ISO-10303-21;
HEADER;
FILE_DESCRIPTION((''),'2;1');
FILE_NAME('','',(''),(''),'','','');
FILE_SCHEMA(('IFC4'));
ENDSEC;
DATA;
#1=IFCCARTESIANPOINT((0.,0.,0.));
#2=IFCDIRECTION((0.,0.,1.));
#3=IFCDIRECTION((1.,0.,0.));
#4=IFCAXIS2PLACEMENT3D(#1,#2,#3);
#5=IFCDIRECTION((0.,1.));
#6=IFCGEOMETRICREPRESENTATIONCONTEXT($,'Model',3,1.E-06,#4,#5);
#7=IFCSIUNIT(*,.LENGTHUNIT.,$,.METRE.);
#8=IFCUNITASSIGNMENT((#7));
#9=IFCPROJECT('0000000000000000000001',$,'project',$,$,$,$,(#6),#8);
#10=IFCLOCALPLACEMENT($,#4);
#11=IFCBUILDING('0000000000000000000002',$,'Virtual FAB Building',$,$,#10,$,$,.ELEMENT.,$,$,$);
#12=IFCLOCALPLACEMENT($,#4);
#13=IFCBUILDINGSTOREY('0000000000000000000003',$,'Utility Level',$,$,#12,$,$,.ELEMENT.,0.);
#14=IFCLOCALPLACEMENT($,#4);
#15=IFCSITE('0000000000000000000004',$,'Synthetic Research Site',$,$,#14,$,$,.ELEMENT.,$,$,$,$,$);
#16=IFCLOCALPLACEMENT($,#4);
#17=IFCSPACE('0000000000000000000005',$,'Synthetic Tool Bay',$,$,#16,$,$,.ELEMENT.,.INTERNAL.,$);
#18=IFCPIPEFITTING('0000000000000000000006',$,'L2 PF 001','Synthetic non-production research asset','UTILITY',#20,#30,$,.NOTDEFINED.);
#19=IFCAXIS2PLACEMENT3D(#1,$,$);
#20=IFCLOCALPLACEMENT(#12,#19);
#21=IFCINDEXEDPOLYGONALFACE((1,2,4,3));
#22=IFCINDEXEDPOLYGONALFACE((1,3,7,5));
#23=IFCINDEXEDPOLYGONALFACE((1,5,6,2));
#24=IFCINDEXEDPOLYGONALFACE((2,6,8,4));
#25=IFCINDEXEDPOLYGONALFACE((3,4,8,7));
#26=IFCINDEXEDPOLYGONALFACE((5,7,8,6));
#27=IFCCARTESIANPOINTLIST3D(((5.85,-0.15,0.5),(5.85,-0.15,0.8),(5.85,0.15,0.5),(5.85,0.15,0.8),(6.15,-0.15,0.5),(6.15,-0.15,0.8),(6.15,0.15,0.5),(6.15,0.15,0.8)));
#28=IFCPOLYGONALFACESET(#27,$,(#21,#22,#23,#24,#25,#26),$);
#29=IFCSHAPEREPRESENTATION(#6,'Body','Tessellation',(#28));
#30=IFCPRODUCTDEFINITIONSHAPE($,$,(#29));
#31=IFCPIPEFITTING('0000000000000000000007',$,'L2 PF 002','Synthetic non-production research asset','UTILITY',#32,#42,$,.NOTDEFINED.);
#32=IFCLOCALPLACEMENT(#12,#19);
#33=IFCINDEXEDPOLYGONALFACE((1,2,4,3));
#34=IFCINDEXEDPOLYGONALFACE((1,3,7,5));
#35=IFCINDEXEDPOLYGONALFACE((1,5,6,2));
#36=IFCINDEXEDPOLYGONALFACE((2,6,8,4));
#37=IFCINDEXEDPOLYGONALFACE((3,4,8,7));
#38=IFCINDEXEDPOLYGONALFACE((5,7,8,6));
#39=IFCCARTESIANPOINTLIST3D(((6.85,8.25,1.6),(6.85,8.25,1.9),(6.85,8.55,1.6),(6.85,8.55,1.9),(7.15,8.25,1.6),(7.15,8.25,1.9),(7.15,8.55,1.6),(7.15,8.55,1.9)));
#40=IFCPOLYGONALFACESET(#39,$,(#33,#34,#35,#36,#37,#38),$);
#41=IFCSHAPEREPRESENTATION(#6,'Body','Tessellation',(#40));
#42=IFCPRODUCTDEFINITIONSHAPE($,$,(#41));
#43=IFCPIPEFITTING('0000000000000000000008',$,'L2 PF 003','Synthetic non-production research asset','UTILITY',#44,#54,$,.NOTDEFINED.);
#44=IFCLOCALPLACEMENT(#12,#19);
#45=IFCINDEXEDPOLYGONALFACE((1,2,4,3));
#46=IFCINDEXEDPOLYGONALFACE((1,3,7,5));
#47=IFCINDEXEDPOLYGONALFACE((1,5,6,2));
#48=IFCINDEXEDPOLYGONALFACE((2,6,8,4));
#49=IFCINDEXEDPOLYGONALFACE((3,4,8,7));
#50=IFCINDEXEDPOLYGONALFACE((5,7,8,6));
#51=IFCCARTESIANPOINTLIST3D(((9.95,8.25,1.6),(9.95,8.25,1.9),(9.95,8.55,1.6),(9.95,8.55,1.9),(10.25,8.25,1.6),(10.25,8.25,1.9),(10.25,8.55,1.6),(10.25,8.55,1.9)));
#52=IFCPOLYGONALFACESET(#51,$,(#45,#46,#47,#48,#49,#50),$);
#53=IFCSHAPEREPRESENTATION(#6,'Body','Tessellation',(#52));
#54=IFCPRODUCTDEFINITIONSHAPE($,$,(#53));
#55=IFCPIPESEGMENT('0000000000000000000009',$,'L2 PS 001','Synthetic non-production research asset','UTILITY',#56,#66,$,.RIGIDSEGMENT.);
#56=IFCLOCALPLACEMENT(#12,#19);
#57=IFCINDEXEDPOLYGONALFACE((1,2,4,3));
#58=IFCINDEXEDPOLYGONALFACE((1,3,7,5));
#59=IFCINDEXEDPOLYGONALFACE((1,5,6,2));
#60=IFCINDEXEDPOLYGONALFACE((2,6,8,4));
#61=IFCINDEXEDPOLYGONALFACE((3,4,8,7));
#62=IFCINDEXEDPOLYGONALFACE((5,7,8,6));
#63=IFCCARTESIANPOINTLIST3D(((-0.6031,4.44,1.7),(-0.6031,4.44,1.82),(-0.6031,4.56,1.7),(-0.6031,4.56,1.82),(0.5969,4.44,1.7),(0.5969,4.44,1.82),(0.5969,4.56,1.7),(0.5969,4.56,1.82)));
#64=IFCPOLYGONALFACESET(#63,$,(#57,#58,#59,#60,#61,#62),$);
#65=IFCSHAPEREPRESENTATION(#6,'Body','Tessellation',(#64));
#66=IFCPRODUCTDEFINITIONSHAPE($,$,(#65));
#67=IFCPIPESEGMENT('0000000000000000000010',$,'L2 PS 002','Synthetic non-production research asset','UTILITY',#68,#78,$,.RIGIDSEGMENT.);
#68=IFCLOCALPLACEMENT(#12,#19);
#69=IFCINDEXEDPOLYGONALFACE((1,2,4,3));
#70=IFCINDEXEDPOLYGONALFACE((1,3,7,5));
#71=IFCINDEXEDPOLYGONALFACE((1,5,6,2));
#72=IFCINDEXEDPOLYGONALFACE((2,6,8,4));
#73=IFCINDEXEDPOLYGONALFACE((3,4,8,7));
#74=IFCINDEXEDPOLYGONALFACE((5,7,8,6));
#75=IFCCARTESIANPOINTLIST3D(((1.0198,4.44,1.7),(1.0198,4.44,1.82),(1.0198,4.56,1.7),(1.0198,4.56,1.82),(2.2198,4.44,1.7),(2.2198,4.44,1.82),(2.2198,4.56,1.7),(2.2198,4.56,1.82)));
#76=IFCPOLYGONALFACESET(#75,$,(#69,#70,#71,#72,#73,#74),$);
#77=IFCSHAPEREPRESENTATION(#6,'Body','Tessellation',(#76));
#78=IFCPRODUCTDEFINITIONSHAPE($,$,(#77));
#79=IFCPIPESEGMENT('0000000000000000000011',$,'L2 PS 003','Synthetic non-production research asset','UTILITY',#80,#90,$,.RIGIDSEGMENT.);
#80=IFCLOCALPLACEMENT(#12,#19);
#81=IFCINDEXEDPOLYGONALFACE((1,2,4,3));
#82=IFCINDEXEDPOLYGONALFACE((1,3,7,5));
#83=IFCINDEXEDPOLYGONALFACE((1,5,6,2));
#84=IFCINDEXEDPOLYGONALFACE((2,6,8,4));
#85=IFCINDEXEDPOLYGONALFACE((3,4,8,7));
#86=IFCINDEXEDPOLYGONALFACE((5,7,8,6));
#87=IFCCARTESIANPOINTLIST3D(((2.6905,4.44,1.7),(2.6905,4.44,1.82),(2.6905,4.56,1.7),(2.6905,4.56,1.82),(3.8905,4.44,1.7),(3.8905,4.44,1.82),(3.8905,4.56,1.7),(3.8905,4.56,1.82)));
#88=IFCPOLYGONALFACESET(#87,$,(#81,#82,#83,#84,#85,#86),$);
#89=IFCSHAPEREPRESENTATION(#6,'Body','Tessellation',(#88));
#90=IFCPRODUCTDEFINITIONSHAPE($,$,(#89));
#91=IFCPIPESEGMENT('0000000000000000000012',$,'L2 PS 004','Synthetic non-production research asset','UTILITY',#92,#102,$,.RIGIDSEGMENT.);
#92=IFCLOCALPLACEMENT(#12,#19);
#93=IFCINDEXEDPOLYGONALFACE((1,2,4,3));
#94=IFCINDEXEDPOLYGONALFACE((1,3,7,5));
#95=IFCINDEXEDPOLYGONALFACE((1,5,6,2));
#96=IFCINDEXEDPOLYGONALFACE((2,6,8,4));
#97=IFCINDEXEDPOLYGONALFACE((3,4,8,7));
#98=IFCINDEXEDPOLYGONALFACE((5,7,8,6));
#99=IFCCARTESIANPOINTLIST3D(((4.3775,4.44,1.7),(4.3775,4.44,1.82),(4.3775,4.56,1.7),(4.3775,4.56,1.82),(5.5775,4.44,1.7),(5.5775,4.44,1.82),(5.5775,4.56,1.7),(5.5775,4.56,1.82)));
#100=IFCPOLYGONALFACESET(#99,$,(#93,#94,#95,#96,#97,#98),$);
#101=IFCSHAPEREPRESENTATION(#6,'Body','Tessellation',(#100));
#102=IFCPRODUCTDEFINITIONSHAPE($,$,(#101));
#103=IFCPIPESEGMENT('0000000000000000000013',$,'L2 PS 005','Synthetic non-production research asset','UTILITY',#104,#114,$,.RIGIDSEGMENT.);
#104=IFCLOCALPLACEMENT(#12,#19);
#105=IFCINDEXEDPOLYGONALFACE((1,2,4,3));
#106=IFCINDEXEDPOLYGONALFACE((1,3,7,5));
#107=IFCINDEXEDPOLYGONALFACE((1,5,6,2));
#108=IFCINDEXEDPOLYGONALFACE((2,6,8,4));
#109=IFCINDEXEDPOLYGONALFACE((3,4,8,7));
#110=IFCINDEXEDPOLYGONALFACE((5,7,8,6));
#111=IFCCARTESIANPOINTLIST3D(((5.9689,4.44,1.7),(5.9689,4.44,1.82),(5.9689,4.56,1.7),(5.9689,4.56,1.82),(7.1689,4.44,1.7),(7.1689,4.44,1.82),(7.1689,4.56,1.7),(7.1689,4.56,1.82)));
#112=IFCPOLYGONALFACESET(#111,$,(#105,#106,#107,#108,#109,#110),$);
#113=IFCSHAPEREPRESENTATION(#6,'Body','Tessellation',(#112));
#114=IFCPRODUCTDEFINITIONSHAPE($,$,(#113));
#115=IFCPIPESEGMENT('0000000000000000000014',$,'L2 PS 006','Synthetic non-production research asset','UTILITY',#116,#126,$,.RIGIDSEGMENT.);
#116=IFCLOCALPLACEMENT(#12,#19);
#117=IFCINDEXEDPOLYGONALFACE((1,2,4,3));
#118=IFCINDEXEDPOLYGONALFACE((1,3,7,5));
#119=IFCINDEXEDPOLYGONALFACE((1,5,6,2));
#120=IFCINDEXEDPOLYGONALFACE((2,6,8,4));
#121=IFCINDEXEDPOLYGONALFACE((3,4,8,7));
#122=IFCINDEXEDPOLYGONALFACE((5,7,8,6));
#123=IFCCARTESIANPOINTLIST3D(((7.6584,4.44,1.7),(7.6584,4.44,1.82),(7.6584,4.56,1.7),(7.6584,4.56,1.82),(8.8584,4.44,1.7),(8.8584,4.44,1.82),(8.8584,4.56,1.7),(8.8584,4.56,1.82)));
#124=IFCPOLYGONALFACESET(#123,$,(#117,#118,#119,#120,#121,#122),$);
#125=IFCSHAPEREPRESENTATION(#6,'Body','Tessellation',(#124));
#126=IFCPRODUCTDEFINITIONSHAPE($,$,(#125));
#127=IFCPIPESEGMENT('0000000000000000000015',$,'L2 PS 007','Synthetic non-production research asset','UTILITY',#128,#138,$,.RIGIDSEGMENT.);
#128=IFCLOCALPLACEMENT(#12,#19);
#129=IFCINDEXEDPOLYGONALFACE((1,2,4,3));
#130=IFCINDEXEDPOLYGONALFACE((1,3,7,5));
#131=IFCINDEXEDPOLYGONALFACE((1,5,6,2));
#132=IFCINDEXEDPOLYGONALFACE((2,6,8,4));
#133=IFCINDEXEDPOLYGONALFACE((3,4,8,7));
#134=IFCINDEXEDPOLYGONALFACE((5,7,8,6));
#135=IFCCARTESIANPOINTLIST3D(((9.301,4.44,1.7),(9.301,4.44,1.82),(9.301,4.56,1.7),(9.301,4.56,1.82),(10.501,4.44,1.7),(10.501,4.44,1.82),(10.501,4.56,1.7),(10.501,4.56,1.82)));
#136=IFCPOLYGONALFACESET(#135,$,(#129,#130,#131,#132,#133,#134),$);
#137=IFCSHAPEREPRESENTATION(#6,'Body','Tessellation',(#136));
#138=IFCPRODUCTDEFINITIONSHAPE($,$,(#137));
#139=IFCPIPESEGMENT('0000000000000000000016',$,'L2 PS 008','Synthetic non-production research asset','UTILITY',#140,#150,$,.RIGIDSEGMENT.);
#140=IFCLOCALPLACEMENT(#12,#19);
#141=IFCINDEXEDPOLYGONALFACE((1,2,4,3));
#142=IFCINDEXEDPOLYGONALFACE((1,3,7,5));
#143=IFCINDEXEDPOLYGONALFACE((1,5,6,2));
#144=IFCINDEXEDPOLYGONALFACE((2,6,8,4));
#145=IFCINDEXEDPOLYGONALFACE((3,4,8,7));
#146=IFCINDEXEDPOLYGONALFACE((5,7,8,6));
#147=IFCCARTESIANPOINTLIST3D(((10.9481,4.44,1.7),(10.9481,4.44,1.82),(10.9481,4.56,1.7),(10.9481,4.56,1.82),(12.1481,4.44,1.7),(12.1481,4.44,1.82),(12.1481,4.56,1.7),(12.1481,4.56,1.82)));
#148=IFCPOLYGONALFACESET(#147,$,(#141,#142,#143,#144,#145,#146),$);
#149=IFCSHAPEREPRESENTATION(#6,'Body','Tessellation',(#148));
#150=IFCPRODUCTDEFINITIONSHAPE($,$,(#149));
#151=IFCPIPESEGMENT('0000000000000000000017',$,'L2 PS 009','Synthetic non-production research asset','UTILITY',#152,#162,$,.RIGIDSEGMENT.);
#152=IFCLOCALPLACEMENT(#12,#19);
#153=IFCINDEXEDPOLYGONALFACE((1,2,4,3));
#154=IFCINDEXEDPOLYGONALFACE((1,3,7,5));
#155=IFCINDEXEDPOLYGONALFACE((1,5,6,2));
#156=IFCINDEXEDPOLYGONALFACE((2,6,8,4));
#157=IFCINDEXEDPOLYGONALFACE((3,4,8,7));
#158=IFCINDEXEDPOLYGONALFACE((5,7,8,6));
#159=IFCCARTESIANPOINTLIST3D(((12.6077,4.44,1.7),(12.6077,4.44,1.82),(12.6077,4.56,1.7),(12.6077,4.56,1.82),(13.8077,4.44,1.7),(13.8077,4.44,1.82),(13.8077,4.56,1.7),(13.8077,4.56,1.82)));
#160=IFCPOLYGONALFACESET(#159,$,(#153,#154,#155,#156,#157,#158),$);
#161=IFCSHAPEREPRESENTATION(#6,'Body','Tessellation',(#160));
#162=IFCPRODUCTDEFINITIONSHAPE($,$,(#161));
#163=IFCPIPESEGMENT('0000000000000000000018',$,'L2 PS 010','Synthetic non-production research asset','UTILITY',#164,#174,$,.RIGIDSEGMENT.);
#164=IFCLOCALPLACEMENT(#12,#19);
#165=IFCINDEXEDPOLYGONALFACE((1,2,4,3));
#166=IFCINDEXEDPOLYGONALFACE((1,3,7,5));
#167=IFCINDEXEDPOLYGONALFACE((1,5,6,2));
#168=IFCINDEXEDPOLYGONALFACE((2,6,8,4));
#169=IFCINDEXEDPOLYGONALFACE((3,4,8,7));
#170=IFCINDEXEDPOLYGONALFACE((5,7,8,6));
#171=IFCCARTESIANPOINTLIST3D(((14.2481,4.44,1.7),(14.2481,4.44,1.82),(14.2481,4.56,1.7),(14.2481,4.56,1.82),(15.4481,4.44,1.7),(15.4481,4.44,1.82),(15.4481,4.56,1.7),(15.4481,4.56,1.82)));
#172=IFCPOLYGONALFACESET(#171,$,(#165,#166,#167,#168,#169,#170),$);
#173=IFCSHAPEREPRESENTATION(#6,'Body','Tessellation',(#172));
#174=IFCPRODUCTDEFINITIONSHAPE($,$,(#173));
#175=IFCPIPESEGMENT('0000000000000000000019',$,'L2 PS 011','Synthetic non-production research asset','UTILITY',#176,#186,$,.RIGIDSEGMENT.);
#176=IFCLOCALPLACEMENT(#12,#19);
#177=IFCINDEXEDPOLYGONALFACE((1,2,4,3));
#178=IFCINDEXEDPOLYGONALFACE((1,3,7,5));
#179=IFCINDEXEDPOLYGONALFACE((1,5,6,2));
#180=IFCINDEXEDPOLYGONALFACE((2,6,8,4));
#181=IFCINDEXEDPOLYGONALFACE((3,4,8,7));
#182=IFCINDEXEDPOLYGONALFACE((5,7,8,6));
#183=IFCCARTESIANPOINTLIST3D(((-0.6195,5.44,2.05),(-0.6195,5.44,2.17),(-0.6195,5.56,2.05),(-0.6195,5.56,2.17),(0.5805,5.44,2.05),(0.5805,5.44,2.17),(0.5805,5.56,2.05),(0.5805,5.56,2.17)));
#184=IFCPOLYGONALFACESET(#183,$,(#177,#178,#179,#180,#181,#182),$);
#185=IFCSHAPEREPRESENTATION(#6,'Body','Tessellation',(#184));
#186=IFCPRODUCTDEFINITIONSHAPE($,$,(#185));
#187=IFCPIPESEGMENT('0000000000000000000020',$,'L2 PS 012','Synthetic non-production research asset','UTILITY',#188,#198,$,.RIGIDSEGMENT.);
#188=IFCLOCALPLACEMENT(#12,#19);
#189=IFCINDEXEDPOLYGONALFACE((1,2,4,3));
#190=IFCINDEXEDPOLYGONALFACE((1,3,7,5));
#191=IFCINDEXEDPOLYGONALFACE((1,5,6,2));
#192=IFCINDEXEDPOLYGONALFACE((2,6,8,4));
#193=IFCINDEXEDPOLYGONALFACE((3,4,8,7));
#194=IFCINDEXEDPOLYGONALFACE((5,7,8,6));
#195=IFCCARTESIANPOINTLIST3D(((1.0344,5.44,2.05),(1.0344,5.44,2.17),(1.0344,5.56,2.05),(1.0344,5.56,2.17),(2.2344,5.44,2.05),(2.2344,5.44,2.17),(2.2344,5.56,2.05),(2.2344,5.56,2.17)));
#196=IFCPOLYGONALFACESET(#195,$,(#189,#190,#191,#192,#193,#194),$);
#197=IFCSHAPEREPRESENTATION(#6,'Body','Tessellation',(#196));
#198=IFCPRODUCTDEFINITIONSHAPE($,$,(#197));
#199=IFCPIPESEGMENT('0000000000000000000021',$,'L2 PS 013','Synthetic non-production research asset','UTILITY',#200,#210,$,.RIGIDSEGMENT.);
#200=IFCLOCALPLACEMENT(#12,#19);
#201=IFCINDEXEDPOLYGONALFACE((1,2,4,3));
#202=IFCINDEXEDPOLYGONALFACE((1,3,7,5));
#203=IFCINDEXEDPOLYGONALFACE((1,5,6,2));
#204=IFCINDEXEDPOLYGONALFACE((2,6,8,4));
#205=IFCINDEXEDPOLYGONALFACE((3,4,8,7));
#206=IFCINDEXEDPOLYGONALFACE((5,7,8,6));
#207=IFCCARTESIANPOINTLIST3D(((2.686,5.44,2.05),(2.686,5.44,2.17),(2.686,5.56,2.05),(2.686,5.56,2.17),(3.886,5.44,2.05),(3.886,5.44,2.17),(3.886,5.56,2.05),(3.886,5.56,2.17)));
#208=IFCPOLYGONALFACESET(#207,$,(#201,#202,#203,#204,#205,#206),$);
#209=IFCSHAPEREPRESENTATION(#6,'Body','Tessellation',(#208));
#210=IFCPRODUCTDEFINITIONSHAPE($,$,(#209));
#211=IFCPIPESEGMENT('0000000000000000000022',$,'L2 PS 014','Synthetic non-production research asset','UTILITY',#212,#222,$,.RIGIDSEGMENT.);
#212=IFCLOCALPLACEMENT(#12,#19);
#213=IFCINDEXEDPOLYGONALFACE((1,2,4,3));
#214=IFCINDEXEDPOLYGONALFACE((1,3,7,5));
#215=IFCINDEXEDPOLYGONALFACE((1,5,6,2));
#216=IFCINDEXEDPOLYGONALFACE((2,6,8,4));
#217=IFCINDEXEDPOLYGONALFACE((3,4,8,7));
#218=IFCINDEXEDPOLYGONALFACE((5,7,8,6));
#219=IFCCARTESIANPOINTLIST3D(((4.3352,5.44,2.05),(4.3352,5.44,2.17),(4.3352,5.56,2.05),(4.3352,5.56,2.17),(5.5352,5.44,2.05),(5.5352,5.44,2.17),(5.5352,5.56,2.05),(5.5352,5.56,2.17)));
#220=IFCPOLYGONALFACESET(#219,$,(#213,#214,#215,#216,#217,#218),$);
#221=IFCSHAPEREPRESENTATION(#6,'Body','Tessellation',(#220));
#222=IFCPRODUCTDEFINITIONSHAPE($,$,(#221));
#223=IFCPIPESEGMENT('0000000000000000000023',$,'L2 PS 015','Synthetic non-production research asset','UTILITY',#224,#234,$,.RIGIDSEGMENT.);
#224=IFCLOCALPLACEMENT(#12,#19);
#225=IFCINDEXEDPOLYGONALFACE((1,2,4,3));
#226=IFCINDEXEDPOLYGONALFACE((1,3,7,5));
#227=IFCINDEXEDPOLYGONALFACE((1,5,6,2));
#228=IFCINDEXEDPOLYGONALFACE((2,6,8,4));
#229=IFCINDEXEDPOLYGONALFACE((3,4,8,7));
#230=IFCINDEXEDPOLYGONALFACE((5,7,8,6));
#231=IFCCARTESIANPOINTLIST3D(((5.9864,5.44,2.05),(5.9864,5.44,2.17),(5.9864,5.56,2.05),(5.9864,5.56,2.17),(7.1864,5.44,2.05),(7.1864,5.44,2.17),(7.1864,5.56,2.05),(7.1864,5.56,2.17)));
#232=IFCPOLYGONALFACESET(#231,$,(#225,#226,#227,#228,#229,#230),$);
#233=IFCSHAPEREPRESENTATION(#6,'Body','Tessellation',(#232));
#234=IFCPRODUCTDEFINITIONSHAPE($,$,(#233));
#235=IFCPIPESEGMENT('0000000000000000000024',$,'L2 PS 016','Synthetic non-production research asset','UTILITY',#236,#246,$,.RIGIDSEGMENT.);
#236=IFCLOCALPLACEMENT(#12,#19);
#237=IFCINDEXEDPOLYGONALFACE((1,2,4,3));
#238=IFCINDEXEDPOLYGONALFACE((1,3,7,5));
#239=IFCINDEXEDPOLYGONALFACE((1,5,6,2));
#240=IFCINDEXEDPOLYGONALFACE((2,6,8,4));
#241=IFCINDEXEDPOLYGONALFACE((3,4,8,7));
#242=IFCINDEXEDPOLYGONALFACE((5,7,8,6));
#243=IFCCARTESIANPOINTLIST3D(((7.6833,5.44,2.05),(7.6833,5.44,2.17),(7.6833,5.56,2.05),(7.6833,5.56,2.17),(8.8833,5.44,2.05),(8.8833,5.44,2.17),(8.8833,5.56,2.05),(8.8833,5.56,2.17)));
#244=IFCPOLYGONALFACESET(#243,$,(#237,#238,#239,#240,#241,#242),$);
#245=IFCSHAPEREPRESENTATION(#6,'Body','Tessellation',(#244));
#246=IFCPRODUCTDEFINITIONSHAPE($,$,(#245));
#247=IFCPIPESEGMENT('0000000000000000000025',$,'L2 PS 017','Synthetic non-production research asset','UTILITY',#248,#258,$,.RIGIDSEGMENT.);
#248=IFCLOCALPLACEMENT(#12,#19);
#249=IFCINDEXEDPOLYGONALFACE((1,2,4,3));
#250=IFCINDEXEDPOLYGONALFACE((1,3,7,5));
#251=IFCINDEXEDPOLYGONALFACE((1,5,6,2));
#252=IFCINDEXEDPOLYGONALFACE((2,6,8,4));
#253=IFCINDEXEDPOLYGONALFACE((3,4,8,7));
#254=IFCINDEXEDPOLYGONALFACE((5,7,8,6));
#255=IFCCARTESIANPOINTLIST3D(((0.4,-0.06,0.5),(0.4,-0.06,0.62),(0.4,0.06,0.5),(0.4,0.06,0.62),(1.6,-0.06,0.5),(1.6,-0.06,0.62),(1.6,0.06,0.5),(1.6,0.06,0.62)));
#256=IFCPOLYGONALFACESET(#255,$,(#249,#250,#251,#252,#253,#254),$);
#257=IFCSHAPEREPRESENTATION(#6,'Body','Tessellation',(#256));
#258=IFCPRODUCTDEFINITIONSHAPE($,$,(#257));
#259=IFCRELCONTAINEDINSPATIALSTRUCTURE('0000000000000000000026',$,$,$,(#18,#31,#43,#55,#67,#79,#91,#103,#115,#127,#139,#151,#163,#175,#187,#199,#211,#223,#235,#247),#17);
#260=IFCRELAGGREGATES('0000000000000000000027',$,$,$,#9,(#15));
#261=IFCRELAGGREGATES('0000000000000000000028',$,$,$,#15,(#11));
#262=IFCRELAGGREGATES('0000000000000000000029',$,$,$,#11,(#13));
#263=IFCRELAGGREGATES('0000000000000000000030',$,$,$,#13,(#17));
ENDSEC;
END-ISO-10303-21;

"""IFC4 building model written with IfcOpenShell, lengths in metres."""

from ifc_helpers import new_model, si_unit, direction, frame, origin_with_axes, origin_2d_with_axis, place, context, project, spatial, rectangle, extrude, element, save


model = new_model("IFC4")

# Units and contexts
model_context = context("Model", 3, precision=1e-06, world=origin_with_axes(), true_north=direction((0.0, 1.0)))
ifc_project = project(units=[si_unit("LENGTHUNIT", "METRE")], contexts=[model_context])

# Site, building, storey, space
site_placement = place(None, origin_with_axes())
site = spatial("IfcSite", under=ifc_project, at=site_placement, Name="Synthetic Research Site", CompositionType="ELEMENT")
building_placement = place(None, origin_with_axes())
building = spatial("IfcBuilding", under=site, at=building_placement, Name="Virtual FAB Building", CompositionType="ELEMENT")
storey_placement = place(None, origin_with_axes())
storey = spatial("IfcBuildingStorey", under=building, at=storey_placement, Name="Utility Level", CompositionType="ELEMENT", Elevation=0.0)
space_placement = place(None, origin_with_axes())
space = spatial("IfcSpace", under=storey, at=space_placement, Name="Synthetic Tool Bay", CompositionType="ELEMENT", PredefinedType="INTERNAL")

# Pipe fittings
for number, where, z_axis, x_axis, name in (
    (1, (6.0, 0.0, 0.5), (0.0, 0.0, 1.0), (1.0, 0.0, 0.0), "L2 PF 001"),
    (2, (7.0, 8.4, 1.6), (0.0, 0.0, 1.0), (1.0, 0.0, 0.0), "L2 PF 002"),
    (3, (10.1, 8.4, 1.6), (0.0, 0.0, 1.0), (1.0, 0.0, 0.0), "L2 PF 003"),
):
    element("IfcPipeFitting", number, at=place(None, frame(where, z_axis=z_axis, x_axis=x_axis)), inside=space, Name=name, Description="Synthetic non-production research asset", ObjectType="UTILITY", PredefinedType="NOTDEFINED", context=model_context, shape_type="SweptSolid", body=[
        extrude(rectangle(XDim=0.3, YDim=0.3, at=origin_2d_with_axis()), origin_with_axes(), (0.0, 0.0, 1.0), 0.3),
    ])

# Pipe segments
for number, where, z_axis, x_axis, name in (
    (4, (-0.0031, 4.5, 1.7), (0.0, 0.0, 1.0), (1.0, 0.0, 0.0), "L2 PS 001"),
    (5, (1.6198, 4.5, 1.7), (0.0, 0.0, 1.0), (1.0, 0.0, 0.0), "L2 PS 002"),
    (6, (3.2905, 4.5, 1.7), (0.0, 0.0, 1.0), (1.0, 0.0, 0.0), "L2 PS 003"),
    (7, (4.9775, 4.5, 1.7), (0.0, 0.0, 1.0), (1.0, 0.0, 0.0), "L2 PS 004"),
    (8, (6.5689, 4.5, 1.7), (0.0, 0.0, 1.0), (1.0, 0.0, 0.0), "L2 PS 005"),
    (9, (8.2584, 4.5, 1.7), (0.0, 0.0, 1.0), (1.0, 0.0, 0.0), "L2 PS 006"),
    (10, (9.901, 4.5, 1.7), (0.0, 0.0, 1.0), (1.0, 0.0, 0.0), "L2 PS 007"),
    (11, (11.5481, 4.5, 1.7), (0.0, 0.0, 1.0), (1.0, 0.0, 0.0), "L2 PS 008"),
    (12, (13.2077, 4.5, 1.7), (0.0, 0.0, 1.0), (1.0, 0.0, 0.0), "L2 PS 009"),
    (13, (14.8481, 4.5, 1.7), (0.0, 0.0, 1.0), (1.0, 0.0, 0.0), "L2 PS 010"),
    (14, (-0.0195, 5.5, 2.05), (0.0, 0.0, 1.0), (1.0, 0.0, 0.0), "L2 PS 011"),
    (15, (1.6344, 5.5, 2.05), (0.0, 0.0, 1.0), (1.0, 0.0, 0.0), "L2 PS 012"),
    (16, (3.286, 5.5, 2.05), (0.0, 0.0, 1.0), (1.0, 0.0, 0.0), "L2 PS 013"),
    (17, (4.9352, 5.5, 2.05), (0.0, 0.0, 1.0), (1.0, 0.0, 0.0), "L2 PS 014"),
    (18, (6.5864, 5.5, 2.05), (0.0, 0.0, 1.0), (1.0, 0.0, 0.0), "L2 PS 015"),
    (19, (8.2833, 5.5, 2.05), (0.0, 0.0, 1.0), (1.0, 0.0, 0.0), "L2 PS 016"),
    (20, (1.0, 0.0, 0.5), (0.0, 0.0, 1.0), (1.0, 0.0, 0.0), "L2 PS 017"),
):
    element("IfcPipeSegment", number, at=place(None, frame(where, z_axis=z_axis, x_axis=x_axis)), inside=space, Name=name, Description="Synthetic non-production research asset", ObjectType="UTILITY", PredefinedType="RIGIDSEGMENT", context=model_context, shape_type="SweptSolid", body=[
        extrude(rectangle(XDim=1.2, YDim=0.12, at=origin_2d_with_axis()), origin_with_axes(), (0.0, 0.0, 1.0), 0.12),
    ])

save(model, "model.ifc")
